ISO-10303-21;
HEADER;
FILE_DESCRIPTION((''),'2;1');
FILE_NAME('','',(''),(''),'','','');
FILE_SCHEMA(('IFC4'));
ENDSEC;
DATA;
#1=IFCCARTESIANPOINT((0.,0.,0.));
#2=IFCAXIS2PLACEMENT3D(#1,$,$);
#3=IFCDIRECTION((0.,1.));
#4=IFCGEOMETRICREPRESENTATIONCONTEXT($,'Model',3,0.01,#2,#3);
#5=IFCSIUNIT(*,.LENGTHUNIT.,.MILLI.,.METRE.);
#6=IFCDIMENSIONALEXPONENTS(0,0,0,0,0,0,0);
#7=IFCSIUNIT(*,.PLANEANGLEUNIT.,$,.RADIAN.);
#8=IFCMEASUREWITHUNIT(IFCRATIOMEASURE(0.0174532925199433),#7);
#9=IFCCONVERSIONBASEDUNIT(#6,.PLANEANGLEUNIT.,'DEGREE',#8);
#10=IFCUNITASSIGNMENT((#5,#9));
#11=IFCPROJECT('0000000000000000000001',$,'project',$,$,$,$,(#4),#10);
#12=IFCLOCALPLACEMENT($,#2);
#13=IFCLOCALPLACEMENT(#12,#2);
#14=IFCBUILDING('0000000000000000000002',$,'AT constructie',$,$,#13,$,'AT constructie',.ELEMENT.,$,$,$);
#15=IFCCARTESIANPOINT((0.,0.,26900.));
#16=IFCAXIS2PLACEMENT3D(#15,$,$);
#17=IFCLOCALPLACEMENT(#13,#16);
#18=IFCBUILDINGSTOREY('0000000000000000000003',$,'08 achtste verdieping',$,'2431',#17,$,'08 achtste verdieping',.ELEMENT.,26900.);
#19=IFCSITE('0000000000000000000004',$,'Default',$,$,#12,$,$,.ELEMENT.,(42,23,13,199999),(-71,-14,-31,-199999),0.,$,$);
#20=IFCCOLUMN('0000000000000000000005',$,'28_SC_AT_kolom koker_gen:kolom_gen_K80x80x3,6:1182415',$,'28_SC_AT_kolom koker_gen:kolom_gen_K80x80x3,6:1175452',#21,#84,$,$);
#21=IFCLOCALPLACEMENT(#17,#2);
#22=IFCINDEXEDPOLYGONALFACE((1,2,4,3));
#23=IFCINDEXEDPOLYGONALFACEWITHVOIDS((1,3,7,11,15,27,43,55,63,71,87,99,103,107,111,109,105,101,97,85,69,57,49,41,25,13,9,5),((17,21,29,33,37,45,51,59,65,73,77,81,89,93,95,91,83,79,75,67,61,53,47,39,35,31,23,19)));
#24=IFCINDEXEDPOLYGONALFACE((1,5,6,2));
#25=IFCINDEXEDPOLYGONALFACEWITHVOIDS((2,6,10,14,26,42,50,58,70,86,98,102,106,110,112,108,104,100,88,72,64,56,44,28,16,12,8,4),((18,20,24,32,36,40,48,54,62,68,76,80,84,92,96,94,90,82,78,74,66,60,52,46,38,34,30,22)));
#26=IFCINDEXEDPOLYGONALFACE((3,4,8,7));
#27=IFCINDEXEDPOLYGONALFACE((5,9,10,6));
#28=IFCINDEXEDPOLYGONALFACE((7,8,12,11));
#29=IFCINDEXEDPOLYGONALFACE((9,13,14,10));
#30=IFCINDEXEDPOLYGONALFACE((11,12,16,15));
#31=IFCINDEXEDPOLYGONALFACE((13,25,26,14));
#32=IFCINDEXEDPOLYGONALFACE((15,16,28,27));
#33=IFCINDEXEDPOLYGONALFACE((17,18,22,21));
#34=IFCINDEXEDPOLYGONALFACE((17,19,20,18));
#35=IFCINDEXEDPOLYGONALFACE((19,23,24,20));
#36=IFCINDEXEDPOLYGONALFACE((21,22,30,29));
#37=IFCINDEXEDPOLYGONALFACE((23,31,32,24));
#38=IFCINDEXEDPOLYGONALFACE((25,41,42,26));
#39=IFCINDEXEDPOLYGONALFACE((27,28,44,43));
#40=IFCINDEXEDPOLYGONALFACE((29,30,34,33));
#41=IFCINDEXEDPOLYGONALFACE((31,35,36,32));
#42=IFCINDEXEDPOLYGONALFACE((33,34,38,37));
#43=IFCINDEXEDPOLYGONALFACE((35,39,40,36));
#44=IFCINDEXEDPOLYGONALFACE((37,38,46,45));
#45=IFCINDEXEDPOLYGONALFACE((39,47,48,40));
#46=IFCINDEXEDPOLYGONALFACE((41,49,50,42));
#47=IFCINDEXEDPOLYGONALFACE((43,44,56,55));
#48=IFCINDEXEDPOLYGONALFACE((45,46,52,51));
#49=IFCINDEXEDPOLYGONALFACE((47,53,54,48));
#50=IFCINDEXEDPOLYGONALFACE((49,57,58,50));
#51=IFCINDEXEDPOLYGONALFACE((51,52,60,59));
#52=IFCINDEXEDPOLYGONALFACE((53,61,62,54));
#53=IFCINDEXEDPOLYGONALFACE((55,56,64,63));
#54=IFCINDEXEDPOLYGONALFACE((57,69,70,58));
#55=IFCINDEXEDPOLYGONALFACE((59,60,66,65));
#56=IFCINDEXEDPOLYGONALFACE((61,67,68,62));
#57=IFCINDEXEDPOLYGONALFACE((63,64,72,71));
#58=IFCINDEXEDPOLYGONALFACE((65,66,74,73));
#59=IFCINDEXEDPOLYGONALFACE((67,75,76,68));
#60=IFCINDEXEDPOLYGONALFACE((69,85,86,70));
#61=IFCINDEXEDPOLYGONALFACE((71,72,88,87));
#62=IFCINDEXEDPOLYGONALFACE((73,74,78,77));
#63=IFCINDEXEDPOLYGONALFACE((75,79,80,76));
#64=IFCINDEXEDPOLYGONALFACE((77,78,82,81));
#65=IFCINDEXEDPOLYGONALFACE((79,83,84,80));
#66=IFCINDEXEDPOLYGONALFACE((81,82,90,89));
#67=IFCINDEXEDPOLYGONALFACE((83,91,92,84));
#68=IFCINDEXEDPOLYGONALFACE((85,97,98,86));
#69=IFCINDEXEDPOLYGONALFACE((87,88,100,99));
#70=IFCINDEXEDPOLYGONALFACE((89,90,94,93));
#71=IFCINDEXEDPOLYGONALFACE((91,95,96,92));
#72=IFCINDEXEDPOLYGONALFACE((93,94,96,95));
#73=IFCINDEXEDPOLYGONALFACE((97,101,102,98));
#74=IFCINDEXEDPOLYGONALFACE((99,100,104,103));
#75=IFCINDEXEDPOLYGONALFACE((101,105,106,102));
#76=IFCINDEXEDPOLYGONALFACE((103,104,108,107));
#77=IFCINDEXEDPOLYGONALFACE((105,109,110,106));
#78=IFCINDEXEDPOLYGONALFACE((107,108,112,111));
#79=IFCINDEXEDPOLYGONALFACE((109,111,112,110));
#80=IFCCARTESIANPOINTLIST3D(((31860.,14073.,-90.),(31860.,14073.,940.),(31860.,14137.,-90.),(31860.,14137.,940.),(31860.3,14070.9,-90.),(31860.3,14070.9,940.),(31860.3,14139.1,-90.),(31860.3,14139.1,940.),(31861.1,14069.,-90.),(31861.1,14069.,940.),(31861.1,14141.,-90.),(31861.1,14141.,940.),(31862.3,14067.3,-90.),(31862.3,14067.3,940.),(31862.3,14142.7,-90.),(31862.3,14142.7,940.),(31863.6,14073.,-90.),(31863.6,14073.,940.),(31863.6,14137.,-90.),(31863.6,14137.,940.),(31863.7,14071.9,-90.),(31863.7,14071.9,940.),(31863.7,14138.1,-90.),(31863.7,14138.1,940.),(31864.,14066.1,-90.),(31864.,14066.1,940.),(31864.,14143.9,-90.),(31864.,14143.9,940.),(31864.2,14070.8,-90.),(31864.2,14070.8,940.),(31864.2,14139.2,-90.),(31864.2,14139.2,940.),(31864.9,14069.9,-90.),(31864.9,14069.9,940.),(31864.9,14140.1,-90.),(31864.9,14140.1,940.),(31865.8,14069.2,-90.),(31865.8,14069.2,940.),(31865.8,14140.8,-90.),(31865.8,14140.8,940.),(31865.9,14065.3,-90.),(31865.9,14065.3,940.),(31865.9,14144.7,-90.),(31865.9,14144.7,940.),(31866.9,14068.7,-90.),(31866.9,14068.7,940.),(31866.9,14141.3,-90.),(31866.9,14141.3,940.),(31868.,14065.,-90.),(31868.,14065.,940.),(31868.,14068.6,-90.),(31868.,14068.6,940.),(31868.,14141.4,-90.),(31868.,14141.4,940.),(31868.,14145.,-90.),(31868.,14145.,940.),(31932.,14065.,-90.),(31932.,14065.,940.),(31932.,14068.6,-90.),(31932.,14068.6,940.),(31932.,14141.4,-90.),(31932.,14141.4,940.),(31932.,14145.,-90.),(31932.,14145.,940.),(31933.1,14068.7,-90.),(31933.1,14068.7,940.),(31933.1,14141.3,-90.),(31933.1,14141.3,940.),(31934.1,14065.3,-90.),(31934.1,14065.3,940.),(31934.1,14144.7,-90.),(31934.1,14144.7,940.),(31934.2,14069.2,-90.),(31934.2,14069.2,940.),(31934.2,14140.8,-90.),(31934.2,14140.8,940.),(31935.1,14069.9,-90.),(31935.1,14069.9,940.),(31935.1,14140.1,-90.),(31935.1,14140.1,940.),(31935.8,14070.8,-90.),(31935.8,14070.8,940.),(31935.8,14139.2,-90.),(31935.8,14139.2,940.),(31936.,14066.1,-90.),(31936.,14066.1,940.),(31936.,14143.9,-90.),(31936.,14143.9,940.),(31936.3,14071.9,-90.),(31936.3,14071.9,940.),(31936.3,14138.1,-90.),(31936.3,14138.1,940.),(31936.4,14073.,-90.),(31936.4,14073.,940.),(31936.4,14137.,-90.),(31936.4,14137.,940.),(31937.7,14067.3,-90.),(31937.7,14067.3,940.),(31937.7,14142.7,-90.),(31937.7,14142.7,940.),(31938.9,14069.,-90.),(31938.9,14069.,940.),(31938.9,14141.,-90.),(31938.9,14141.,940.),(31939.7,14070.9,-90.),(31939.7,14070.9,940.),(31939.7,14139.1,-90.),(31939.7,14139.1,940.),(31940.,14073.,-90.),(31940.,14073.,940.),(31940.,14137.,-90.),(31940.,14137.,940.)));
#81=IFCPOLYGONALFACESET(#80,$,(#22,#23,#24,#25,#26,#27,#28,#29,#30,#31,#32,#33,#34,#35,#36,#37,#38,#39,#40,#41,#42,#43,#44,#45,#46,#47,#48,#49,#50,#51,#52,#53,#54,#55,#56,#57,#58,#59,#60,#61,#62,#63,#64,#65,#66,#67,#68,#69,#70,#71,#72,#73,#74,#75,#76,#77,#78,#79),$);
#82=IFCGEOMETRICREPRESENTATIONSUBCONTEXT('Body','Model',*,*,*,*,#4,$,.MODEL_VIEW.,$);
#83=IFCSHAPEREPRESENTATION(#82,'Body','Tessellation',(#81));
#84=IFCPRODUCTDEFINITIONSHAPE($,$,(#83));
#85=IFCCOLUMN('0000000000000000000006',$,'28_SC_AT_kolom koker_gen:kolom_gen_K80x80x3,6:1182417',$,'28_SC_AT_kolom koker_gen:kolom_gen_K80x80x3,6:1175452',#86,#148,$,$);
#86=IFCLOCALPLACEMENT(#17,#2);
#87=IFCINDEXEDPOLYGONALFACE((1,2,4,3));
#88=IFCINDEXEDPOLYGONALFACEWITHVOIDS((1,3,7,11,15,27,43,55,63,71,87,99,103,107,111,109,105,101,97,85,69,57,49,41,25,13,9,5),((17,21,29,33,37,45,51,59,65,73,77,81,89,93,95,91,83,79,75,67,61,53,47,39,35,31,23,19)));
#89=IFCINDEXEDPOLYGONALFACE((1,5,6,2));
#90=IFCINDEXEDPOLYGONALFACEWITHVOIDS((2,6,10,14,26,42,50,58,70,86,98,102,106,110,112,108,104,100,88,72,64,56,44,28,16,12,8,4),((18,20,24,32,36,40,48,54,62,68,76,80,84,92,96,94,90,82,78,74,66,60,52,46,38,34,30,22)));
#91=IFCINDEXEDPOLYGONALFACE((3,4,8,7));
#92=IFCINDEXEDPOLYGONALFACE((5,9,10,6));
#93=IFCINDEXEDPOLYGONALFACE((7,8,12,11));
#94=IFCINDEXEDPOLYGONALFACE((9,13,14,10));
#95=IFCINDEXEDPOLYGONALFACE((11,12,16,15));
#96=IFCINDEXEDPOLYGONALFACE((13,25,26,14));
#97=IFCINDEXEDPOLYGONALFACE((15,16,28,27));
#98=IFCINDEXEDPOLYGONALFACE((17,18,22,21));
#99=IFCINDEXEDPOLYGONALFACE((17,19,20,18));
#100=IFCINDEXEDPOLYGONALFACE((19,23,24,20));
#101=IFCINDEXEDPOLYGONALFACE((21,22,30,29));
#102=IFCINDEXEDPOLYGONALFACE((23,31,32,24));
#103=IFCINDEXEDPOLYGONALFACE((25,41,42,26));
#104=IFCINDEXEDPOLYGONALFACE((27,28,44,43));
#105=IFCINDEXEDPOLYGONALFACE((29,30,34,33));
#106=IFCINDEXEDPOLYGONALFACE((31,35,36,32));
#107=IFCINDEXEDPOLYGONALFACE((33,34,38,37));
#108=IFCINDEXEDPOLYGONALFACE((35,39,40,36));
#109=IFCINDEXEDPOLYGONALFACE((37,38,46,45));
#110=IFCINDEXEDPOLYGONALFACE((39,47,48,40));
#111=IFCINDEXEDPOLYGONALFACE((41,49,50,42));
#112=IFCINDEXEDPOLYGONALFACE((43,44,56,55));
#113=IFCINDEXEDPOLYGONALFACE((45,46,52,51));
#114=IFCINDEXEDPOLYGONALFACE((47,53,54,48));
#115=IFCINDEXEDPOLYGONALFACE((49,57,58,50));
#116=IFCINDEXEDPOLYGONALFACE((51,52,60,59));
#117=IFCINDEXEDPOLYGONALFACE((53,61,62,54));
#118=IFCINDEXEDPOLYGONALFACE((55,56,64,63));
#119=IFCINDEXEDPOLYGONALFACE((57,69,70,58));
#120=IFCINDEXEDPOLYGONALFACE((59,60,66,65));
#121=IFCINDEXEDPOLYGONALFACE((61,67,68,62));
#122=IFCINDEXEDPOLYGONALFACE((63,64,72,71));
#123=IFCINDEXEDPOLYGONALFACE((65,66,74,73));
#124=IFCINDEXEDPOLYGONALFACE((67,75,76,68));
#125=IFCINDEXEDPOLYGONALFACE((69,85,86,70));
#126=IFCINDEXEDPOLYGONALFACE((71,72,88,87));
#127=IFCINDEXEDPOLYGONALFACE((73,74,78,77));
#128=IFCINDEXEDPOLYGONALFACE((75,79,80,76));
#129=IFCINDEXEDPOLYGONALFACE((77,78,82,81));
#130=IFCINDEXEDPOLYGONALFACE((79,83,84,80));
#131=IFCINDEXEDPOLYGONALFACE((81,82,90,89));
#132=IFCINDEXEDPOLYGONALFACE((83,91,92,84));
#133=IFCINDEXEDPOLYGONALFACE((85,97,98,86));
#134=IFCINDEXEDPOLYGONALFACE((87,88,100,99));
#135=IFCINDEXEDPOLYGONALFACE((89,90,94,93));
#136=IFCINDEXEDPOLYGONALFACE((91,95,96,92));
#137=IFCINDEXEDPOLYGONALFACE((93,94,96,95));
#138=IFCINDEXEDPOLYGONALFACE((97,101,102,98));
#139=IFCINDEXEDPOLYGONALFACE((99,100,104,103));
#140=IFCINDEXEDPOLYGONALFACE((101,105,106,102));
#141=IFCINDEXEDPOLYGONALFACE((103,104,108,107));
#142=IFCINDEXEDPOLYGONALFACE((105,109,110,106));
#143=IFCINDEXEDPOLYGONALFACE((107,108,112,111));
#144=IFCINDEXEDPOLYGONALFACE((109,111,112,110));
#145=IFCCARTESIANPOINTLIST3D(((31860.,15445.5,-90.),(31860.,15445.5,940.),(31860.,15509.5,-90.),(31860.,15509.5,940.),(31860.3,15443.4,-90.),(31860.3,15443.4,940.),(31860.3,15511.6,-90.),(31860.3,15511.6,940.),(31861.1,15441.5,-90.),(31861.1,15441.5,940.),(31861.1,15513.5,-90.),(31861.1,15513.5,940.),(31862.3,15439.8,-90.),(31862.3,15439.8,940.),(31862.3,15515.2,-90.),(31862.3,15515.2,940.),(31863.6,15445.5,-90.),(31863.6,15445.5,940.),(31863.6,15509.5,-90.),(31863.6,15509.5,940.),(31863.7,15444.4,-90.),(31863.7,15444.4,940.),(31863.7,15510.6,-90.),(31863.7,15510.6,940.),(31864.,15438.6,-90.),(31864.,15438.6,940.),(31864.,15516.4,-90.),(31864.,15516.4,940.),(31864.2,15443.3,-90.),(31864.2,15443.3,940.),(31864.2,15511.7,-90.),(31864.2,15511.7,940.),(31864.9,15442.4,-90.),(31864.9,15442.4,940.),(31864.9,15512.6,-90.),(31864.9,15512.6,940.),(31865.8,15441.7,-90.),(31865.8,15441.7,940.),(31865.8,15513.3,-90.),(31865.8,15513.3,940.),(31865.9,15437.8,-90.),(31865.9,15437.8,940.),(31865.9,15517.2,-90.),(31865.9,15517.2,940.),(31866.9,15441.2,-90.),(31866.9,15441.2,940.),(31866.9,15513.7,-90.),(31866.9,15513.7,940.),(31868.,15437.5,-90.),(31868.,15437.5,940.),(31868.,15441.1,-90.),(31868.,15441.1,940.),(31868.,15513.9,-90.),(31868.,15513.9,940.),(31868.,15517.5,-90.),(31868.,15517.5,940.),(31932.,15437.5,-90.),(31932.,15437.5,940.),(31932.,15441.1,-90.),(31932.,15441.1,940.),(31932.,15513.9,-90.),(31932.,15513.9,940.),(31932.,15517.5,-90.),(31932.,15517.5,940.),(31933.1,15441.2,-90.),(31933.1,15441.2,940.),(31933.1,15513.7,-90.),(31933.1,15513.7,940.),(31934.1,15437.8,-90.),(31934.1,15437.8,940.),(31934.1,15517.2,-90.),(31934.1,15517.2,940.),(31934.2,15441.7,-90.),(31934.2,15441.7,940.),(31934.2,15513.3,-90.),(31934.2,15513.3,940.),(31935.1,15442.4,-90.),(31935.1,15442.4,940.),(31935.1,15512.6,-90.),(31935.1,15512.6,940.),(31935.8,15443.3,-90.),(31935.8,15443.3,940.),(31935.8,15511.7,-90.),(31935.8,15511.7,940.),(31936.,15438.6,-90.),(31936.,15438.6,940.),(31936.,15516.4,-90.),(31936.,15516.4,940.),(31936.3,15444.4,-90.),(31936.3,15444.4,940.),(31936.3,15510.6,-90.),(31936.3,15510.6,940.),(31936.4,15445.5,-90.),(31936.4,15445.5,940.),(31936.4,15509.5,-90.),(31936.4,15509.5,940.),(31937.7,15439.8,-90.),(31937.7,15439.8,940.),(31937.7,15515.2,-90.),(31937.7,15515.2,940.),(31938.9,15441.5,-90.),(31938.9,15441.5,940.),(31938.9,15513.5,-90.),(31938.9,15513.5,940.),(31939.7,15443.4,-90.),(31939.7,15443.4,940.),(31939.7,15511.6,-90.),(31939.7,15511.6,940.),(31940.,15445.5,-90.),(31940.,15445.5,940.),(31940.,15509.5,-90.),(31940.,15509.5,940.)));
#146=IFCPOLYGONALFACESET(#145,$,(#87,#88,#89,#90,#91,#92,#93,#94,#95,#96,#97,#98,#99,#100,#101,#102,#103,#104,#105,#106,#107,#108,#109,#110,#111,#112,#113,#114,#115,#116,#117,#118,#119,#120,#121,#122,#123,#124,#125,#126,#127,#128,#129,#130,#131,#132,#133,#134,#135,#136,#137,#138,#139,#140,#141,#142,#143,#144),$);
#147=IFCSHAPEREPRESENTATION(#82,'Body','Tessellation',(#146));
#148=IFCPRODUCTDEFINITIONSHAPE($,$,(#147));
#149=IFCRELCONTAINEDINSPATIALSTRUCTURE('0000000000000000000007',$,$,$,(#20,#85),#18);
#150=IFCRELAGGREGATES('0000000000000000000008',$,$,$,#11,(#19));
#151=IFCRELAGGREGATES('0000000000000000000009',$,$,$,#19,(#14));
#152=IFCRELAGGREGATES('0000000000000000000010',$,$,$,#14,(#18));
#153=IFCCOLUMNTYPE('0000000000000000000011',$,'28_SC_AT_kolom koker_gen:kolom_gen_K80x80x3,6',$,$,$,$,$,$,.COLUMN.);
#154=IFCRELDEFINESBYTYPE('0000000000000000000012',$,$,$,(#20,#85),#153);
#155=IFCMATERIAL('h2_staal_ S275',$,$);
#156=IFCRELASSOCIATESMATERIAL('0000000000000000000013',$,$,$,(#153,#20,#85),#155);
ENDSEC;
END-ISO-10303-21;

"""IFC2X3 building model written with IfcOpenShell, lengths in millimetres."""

from ifc_helpers import new_model, entity, si_unit, converted_unit, direction, frame, frame_2d, origin, place, context, subcontext, project, spatial, polyline, circle_curve, parameter, trimmed, segment, composite_curve, outline, extrude, source, transform, mapped, material, type_object, type_shapes, element, save


model = new_model("IFC2X3")

# Units and contexts
model_context = context("Model", 3, precision=0.01, world=origin(), true_north=direction((0.0, 1.0)))
body_context = subcontext(model_context, "Body", "Model", "MODEL_VIEW")
ifc_project = project(units=[si_unit("LENGTHUNIT", "METRE", prefix="MILLI"), converted_unit("PLANEANGLEUNIT", "DEGREE", entity("IfcRatioMeasure", 0.0174532925199433), si_unit("PLANEANGLEUNIT", "RADIAN"), dimensions=[0, 0, 0, 0, 0, 0, 0])], contexts=[model_context])

# Site, building, storey
site_placement = place(None, origin())
site = spatial("IfcSite", under=ifc_project, at=site_placement, Name="Default", CompositionType="ELEMENT", RefLatitude=(42, 23, 13, 199999), RefLongitude=(-71, -14, -31, -199999), RefElevation=0.0)
building_placement = place(site_placement, origin())
building = spatial("IfcBuilding", under=site, at=building_placement, Name="AT constructie", LongName="AT constructie", CompositionType="ELEMENT")
storey_placement = place(building_placement, frame((0.0, 0.0, 26900.0)))
storey = spatial("IfcBuildingStorey", under=building, at=storey_placement, Name="08 achtste verdieping", ObjectType="2431", LongName="08 achtste verdieping", CompositionType="ELEMENT", Elevation=26900.0)

# Columns
ifc_material_1 = material(Name="h2_staal_ S275")
column_type_1 = type_object("IfcColumnType", Name="28_SC_AT_kolom koker_gen:kolom_gen_K80x80x3,6", PredefinedType="COLUMN", material=ifc_material_1)
shared_shape_1 = source(origin(), body_context, "Body", "SweptSolid", [
    extrude(outline(composite_curve([segment(trimmed(circle_curve(frame_2d((32.0, 32.0), x_axis=(1.0, 0.0)), 8.0), [parameter(360.0)], [parameter(90.0)], True, "PARAMETER"), True, "CONTINUOUS"), segment(polyline([(32.0, 40.0), (-32.0, 40.0)]), True, "CONTINUOUS"), segment(trimmed(circle_curve(frame_2d((-32.0, 32.0), x_axis=(1.0, 0.0)), 8.0), [parameter(90.0)], [parameter(180.0)], True, "PARAMETER"), True, "CONTINUOUS"), segment(polyline([(-40.0, 32.0), (-40.0, -32.0)]), True, "CONTINUOUS"), segment(trimmed(circle_curve(frame_2d((-32.0, -32.0), x_axis=(1.0, 0.0)), 8.0), [parameter(180.0)], [parameter(270.0)], True, "PARAMETER"), True, "CONTINUOUS"), segment(polyline([(-32.0, -40.0), (32.0, -40.0)]), True, "CONTINUOUS"), segment(trimmed(circle_curve(frame_2d((32.0, -32.0), x_axis=(1.0, 0.0)), 8.0), [parameter(270.0)], [parameter(0.0)], True, "PARAMETER"), True, "CONTINUOUS"), segment(polyline([(40.0, -32.0), (40.0, 32.0)]), True, "CONTINUOUS")], self_intersect=False), holes=[composite_curve([segment(polyline([(-32.0, 36.4), (32.0, 36.4)]), True, "CONTINUOUS"), segment(trimmed(circle_curve(frame_2d((32.0, 32.0), x_axis=(1.0, 0.0)), 4.4), [parameter(360.0)], [parameter(90.0)], True, "PARAMETER"), False, "CONTINUOUS"), segment(polyline([(36.4, 32.0), (36.4, -32.0)]), True, "CONTINUOUS"), segment(trimmed(circle_curve(frame_2d((32.0, -32.0), x_axis=(1.0, 0.0)), 4.4), [parameter(270.0)], [parameter(360.0)], True, "PARAMETER"), False, "CONTINUOUS"), segment(polyline([(32.0, -36.4), (-32.0, -36.4)]), True, "CONTINUOUS"), segment(trimmed(circle_curve(frame_2d((-32.0, -32.0), x_axis=(1.0, 0.0)), 4.4), [parameter(180.0)], [parameter(270.0)], True, "PARAMETER"), False, "CONTINUOUS"), segment(polyline([(-36.4, -32.0), (-36.4, 32.0)]), True, "CONTINUOUS"), segment(trimmed(circle_curve(frame_2d((-32.0, 32.0), x_axis=(1.0, 0.0)), 4.4), [parameter(90.0)], [parameter(180.0)], True, "PARAMETER"), False, "CONTINUOUS")], self_intersect=False)]), frame((0.0, 0.0, 26810.0), z_axis=(0.0, 0.0, 1.0), x_axis=(-1.0, 0.0, 0.0)), (0.0, 0.0, 1.0), 1030.0),
])
type_shapes(column_type_1, [shared_shape_1])
for number, where, name in (
    (1, (31900.0, 14105.0, -26900.0), "28_SC_AT_kolom koker_gen:kolom_gen_K80x80x3,6:1182415"),
    (2, (31900.0, 15477.5, -26900.0), "28_SC_AT_kolom koker_gen:kolom_gen_K80x80x3,6:1182417"),
):
    element("IfcColumn", number, at=place(storey_placement, frame(where)), inside=storey, type_object=column_type_1, material=ifc_material_1, Name=name, ObjectType="28_SC_AT_kolom koker_gen:kolom_gen_K80x80x3,6:1175452", context=body_context, shape_type="MappedRepresentation", body=[
        mapped(shared_shape_1, transform((0.0, 0.0, 0.0), scale=1.0)),
    ])

save(model, "model.ifc")
